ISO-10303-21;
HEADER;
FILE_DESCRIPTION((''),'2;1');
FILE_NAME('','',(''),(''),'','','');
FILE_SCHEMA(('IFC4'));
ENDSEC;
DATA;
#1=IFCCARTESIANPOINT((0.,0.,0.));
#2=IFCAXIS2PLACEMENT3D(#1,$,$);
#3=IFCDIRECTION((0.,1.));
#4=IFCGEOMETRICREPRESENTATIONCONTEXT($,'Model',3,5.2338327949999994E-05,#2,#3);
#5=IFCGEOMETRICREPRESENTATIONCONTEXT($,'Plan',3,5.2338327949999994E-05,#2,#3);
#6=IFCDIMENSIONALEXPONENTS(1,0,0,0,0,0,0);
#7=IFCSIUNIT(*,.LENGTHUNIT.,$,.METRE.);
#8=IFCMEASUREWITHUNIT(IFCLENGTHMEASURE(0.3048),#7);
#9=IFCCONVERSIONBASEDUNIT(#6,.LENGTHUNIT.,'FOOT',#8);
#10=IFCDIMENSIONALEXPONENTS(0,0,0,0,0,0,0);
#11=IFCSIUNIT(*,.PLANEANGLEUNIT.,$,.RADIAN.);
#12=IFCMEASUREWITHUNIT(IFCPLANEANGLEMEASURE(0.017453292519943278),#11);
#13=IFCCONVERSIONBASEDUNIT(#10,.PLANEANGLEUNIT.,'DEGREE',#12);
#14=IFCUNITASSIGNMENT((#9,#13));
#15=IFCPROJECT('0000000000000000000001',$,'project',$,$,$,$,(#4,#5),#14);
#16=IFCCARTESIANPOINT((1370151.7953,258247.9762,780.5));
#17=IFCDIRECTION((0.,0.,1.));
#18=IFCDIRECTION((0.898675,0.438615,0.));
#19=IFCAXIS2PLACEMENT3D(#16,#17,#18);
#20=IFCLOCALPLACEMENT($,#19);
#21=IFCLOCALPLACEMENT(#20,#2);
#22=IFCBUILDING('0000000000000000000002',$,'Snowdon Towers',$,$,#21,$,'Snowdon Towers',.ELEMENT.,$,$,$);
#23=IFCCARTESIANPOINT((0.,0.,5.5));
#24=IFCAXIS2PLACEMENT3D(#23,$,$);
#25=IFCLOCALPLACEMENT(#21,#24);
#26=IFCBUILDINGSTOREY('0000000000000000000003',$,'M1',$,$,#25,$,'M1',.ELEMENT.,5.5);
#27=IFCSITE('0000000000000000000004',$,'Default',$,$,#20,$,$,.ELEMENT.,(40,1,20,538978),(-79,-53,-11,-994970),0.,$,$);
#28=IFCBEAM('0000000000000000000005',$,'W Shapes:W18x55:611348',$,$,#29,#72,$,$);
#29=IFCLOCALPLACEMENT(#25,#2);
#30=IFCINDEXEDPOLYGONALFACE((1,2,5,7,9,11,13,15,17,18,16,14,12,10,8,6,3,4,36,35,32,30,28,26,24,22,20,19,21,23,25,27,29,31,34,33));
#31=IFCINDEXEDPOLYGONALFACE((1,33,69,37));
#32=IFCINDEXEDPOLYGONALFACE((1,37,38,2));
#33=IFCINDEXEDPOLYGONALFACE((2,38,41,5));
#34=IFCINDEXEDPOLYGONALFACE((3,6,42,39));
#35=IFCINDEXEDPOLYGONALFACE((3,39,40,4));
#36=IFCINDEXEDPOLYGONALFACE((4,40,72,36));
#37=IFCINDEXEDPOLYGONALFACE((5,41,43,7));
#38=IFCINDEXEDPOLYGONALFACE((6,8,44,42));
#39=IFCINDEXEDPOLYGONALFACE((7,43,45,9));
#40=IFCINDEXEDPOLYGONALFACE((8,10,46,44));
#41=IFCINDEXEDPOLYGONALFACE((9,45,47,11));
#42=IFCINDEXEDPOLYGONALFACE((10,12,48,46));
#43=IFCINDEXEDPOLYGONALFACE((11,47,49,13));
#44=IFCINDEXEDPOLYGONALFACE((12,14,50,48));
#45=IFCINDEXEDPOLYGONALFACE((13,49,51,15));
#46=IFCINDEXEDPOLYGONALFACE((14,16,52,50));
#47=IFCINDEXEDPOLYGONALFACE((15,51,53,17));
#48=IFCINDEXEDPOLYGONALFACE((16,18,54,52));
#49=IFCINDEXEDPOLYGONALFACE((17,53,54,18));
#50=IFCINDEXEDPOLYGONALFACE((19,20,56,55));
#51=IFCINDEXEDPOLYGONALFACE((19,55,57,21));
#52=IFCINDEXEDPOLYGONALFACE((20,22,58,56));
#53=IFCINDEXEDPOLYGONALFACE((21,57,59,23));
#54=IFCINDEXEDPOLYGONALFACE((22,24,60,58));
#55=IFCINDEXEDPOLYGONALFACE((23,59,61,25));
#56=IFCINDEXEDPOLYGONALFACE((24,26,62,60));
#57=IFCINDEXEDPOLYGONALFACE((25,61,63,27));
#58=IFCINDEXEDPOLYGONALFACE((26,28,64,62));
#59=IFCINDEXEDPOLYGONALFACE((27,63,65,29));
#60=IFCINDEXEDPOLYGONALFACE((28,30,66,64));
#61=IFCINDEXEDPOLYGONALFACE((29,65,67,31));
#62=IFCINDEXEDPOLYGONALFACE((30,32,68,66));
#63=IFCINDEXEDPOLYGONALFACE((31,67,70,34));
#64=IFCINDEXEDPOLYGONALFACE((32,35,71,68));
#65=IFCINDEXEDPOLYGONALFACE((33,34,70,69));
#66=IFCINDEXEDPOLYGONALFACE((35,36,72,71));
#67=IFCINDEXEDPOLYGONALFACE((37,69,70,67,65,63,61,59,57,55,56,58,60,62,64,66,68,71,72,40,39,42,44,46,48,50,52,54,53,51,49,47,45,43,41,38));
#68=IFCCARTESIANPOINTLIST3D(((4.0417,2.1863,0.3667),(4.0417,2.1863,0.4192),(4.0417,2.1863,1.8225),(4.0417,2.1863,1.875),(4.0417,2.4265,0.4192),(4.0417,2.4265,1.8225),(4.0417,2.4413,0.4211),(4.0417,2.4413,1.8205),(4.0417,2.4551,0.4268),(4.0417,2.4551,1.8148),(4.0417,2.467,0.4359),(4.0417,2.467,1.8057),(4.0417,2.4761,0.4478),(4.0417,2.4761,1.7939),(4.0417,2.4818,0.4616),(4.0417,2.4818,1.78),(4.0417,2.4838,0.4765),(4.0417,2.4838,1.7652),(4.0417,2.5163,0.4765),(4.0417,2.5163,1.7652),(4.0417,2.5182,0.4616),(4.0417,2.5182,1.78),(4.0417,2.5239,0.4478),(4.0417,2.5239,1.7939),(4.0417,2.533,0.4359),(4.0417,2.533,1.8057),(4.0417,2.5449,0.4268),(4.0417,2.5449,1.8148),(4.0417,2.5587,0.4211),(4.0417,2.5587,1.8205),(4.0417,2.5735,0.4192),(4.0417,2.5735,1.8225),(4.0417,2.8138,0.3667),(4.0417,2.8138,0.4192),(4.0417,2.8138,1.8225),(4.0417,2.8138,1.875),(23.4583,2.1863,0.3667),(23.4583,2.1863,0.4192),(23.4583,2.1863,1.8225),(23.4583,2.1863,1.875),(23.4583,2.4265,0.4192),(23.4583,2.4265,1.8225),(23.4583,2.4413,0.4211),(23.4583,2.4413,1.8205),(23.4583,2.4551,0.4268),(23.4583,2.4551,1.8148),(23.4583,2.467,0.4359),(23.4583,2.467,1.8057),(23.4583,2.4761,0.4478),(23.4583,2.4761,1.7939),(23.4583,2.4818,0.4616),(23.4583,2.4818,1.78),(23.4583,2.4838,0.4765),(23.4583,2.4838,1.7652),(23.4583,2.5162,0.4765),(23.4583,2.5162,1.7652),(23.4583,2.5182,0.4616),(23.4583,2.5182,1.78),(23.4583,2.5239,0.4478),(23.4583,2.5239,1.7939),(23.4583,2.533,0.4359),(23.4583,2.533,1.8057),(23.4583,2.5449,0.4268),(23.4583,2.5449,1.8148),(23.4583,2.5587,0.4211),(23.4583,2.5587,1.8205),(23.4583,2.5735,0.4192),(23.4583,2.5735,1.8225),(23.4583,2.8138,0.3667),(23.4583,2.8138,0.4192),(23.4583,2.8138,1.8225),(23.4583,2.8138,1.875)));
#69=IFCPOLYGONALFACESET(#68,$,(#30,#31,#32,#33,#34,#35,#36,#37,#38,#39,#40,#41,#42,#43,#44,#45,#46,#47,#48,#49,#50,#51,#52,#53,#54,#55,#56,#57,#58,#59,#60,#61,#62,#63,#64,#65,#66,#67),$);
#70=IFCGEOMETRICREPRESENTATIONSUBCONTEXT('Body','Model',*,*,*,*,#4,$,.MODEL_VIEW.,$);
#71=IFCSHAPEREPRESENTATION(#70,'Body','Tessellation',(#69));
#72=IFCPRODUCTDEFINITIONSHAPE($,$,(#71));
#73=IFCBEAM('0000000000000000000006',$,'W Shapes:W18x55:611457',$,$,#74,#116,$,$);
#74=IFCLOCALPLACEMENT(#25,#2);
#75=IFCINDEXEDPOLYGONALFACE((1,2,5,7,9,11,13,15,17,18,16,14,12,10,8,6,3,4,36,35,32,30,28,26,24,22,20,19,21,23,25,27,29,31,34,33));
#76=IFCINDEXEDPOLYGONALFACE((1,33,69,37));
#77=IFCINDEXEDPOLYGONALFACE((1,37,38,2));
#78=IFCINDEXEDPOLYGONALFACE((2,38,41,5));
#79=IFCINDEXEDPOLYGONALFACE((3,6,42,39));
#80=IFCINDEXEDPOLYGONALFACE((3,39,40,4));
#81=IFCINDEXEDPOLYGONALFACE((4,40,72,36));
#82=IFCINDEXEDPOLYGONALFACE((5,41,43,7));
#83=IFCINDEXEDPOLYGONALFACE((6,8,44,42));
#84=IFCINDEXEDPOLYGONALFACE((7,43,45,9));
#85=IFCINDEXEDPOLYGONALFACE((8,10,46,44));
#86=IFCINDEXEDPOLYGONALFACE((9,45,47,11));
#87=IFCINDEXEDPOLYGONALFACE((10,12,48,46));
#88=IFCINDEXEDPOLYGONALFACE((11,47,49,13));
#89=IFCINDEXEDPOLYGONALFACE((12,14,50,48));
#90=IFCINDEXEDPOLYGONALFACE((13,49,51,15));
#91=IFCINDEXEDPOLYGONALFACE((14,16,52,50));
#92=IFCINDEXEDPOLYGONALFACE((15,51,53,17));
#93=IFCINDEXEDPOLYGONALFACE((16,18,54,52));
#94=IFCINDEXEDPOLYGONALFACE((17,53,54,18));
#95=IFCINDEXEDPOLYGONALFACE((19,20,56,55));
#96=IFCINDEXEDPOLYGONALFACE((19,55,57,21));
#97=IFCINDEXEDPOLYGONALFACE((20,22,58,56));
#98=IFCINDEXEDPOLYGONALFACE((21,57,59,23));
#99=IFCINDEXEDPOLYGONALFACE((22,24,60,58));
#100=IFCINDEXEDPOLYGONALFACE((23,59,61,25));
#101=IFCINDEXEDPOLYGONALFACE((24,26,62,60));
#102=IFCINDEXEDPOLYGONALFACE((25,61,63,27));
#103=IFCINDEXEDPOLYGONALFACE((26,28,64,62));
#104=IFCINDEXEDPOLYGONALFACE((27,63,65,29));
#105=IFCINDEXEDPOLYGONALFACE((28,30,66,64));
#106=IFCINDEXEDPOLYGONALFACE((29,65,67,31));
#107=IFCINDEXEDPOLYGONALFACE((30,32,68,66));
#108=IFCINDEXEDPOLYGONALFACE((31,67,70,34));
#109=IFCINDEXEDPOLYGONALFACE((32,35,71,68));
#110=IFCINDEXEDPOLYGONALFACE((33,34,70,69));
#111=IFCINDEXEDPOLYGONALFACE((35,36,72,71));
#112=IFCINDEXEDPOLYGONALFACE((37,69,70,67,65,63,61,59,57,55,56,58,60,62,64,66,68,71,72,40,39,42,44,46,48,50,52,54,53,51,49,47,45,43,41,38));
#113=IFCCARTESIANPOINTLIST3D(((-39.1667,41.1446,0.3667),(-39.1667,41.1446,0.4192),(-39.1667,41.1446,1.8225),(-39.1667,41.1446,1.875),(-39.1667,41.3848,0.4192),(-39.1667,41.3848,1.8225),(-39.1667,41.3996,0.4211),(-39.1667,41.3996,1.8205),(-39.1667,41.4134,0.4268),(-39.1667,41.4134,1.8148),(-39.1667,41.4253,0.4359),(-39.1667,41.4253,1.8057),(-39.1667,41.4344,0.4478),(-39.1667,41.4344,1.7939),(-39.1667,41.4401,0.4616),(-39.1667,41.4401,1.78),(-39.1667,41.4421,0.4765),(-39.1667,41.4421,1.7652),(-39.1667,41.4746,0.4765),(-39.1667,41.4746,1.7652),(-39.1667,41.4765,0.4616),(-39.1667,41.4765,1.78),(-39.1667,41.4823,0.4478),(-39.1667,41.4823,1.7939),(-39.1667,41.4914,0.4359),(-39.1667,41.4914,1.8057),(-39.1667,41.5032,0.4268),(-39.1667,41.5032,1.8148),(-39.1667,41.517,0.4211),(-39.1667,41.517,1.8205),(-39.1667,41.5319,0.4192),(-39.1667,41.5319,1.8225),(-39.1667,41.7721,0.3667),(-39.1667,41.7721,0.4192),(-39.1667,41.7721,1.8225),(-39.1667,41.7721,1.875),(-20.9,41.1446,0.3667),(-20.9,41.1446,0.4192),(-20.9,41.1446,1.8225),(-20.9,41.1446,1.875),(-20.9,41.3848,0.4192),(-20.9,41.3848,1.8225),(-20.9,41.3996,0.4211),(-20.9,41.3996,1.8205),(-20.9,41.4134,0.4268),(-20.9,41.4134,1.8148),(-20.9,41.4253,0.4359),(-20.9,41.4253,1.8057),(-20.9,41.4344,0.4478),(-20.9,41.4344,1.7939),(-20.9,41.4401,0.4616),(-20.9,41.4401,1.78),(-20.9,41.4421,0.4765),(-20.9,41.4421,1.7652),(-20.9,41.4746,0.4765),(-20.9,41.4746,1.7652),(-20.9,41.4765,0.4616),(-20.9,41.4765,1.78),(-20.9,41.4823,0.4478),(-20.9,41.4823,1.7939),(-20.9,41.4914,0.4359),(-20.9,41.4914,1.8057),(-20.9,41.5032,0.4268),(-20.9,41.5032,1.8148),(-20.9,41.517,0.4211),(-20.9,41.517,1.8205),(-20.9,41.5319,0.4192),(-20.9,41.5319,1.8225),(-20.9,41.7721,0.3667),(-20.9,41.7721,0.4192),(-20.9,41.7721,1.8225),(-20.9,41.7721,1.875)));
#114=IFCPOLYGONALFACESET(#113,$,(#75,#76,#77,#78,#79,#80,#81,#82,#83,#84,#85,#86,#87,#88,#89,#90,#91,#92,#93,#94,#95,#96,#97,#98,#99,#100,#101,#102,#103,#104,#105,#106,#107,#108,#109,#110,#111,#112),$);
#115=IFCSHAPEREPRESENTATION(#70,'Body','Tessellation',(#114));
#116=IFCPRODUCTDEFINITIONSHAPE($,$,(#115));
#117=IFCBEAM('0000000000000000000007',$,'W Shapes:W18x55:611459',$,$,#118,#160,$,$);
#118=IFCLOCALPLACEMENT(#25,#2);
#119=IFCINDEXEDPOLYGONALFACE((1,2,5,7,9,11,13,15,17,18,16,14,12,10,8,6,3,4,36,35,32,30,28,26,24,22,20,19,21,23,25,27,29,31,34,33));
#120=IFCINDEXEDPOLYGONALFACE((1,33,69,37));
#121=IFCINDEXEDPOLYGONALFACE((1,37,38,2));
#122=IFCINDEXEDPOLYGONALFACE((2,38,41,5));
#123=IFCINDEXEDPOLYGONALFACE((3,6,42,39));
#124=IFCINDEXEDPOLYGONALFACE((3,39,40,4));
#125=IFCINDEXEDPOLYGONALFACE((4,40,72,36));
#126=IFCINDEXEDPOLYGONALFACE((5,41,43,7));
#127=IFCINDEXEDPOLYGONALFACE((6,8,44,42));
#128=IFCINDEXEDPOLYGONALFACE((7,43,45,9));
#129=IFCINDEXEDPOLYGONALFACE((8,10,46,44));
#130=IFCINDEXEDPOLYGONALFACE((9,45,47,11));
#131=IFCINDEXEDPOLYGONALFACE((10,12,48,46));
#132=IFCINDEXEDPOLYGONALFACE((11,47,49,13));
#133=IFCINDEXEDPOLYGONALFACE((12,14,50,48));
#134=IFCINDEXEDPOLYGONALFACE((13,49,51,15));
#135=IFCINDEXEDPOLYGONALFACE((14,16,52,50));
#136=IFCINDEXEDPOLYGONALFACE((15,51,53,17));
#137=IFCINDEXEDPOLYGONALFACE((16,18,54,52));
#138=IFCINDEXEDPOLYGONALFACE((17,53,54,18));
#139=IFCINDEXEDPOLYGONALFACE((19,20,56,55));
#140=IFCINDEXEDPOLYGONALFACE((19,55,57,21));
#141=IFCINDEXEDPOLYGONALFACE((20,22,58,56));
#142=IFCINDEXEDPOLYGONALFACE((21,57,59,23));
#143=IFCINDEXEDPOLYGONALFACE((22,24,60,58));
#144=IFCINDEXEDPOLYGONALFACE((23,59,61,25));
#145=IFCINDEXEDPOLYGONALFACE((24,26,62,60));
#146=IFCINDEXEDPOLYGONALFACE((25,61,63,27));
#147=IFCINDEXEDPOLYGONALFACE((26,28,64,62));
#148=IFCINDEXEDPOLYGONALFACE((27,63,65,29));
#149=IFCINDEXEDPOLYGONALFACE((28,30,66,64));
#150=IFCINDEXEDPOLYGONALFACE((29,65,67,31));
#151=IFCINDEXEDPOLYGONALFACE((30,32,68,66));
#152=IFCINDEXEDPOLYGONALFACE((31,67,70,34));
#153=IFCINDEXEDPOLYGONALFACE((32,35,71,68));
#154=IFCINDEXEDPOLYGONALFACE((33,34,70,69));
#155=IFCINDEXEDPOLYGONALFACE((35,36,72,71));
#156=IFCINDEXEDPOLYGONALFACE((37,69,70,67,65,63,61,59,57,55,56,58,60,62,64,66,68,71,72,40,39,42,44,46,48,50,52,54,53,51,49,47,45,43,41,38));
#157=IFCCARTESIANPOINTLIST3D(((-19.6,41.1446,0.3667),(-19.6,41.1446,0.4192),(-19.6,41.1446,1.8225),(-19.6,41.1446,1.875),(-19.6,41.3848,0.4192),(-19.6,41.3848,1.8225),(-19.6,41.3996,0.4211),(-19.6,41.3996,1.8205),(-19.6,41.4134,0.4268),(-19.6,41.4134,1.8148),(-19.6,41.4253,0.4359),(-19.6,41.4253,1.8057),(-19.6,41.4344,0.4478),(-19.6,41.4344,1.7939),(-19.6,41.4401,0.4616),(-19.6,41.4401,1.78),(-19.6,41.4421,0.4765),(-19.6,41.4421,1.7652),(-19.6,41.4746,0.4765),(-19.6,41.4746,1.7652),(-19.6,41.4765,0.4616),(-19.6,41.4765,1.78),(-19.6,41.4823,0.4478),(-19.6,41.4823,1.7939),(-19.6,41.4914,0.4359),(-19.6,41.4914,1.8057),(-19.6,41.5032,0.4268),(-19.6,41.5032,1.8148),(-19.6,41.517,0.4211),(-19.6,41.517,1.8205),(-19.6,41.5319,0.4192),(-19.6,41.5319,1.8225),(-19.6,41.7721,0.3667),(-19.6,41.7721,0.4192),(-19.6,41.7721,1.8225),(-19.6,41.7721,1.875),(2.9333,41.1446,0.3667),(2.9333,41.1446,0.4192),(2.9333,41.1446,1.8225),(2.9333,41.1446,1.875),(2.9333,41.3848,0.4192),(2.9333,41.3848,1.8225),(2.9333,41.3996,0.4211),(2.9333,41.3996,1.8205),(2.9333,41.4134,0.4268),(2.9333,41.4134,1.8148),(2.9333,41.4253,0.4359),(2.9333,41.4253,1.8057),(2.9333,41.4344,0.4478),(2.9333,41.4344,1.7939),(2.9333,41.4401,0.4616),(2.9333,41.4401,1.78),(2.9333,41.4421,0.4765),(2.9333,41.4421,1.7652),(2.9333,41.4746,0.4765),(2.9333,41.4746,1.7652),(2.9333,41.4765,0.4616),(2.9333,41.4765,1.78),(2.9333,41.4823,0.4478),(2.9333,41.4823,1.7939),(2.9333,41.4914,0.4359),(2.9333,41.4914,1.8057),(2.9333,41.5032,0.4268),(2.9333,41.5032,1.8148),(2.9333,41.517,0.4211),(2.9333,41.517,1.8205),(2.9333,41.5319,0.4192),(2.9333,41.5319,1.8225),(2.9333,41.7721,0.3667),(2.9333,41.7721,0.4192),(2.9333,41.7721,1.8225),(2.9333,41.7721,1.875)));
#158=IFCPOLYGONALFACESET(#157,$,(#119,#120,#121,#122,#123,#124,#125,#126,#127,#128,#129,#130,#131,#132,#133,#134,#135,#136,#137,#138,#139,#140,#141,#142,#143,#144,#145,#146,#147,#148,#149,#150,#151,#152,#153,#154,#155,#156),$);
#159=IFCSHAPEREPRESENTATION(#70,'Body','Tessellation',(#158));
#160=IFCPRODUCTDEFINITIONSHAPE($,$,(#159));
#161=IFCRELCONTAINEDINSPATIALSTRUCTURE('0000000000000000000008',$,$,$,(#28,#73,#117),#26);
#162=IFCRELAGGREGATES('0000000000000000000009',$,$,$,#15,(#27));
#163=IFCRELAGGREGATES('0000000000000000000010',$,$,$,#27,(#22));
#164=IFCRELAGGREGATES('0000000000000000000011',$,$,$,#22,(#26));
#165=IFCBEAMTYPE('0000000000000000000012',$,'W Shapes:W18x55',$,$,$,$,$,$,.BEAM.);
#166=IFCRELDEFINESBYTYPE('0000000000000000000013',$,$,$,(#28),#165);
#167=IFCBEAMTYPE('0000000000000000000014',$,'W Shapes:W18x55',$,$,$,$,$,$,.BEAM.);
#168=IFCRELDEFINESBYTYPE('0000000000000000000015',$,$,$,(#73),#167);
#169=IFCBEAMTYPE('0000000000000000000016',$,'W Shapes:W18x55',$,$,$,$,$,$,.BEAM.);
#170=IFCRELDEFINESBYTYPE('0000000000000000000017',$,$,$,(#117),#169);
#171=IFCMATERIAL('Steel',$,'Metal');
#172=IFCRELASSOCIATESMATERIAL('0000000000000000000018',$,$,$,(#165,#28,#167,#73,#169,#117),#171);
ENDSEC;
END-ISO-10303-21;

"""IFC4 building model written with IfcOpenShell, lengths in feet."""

from ifc_helpers import new_model, entity, si_unit, converted_unit, direction, frame, origin, place, context, subcontext, project, spatial, line, arc, indexed_curve, outline, extrude, source, transform, mapped, material, type_object, type_shapes, element, save


model = new_model("IFC4")

# Units and contexts
model_context = context("Model", 3, precision=5.2338327949999994e-05, world=origin(), true_north=direction((0.0, 1.0)))
plan_context = context("Plan", 3, precision=5.2338327949999994e-05, world=origin(), true_north=direction((0.0, 1.0)))
body_context = subcontext(model_context, "Body", "Model", "MODEL_VIEW")
ifc_project = project(units=[converted_unit("LENGTHUNIT", "FOOT", entity("IfcLengthMeasure", 0.3048), si_unit("LENGTHUNIT", "METRE"), dimensions=[1, 0, 0, 0, 0, 0, 0]), converted_unit("PLANEANGLEUNIT", "DEGREE", entity("IfcPlaneAngleMeasure", 0.017453292519943278), si_unit("PLANEANGLEUNIT", "RADIAN"), dimensions=[0, 0, 0, 0, 0, 0, 0])], contexts=[model_context, plan_context])

# Site, building, storey
site_placement = place(None, frame((1370151.7953, 258247.9762, 780.5), z_axis=(0.0, 0.0, 1.0), x_axis=(0.898675, 0.438615, 0.0)))
site = spatial("IfcSite", under=ifc_project, at=site_placement, Name="Default", CompositionType="ELEMENT", RefLatitude=(40, 1, 20, 538978), RefLongitude=(-79, -53, -11, -994970), RefElevation=0.0)
building_placement = place(site_placement, origin())
building = spatial("IfcBuilding", under=site, at=building_placement, Name="Snowdon Towers", LongName="Snowdon Towers", CompositionType="ELEMENT")
storey_placement = place(building_placement, frame((0.0, 0.0, 5.5)))
storey = spatial("IfcBuildingStorey", under=building, at=storey_placement, Name="M1", LongName="M1", CompositionType="ELEMENT", Elevation=5.5)

# Beams
ifc_material_1 = material(Name="Steel", Category="Metal")
beam_type_1 = type_object("IfcBeamType", Name="W Shapes:W18x55", PredefinedType="BEAM", material=ifc_material_1)
shared_shape_1 = source(origin(), body_context, "Body", "SweptSolid", [
    extrude(outline(indexed_curve([(-0.7542, -0.3138), (-0.7017, -0.3138), (-0.7017, -0.0735), (-0.6849, -0.033), (-0.6444, -0.0162), (0.6444, -0.0162), (0.6849, -0.033), (0.7017, -0.0735), (0.7017, -0.3138), (0.7542, -0.3138), (0.7542, 0.3138), (0.7017, 0.3138), (0.7017, 0.0735), (0.6849, 0.033), (0.6444, 0.0163), (-0.6444, 0.0163), (-0.6849, 0.033), (-0.7017, 0.0735), (-0.7017, 0.3137), (-0.7542, 0.3137)], segments=[line(1, 2, 3), arc(3, 4, 5), line(5, 6), arc(6, 7, 8), line(8, 9, 10, 11, 12, 13), arc(13, 14, 15), line(15, 16), arc(16, 17, 18), line(18, 19, 20, 1)], self_intersect=False)), frame((-9.7917, 0.0, 0.0), z_axis=(1.0, 0.0, 0.0), x_axis=(0.0, 0.0, -1.0)), (0.0, 0.0, 1.0), 19.4167),
])
type_shapes(beam_type_1, [shared_shape_1])
beam_1_placement = place(storey_placement, frame((13.8333, 2.5, 1.1208)))
element("IfcBeam", 1, at=beam_1_placement, inside=storey, type_object=beam_type_1, material=ifc_material_1, Name="W Shapes:W18x55:611348", context=body_context, shape_type="MappedRepresentation", body=[
    mapped(shared_shape_1, transform((0.0, 0.0, 0.0), scale=1.0)),
])
beam_type_2 = type_object("IfcBeamType", Name="W Shapes:W18x55", PredefinedType="BEAM", material=ifc_material_1)
shared_shape_2 = source(origin(), body_context, "Body", "SweptSolid", [
    extrude(outline(indexed_curve([(-0.7542, -0.3138), (-0.7017, -0.3138), (-0.7017, -0.0735), (-0.6849, -0.033), (-0.6444, -0.0162), (0.6444, -0.0162), (0.6849, -0.033), (0.7017, -0.0735), (0.7017, -0.3138), (0.7542, -0.3138), (0.7542, 0.3138), (0.7017, 0.3138), (0.7017, 0.0735), (0.6849, 0.033), (0.6444, 0.0163), (-0.6444, 0.0163), (-0.6849, 0.033), (-0.7017, 0.0735), (-0.7017, 0.3137), (-0.7542, 0.3137)], segments=[line(1, 2, 3), arc(3, 4, 5), line(5, 6), arc(6, 7, 8), line(8, 9, 10, 11, 12, 13), arc(13, 14, 15), line(15, 16), arc(16, 17, 18), line(18, 19, 20, 1)], self_intersect=False)), frame((-9.1875, 0.0, 0.0), z_axis=(1.0, 0.0, 0.0), x_axis=(0.0, 0.0, -1.0)), (0.0, 0.0, 1.0), 18.2667),
])
type_shapes(beam_type_2, [shared_shape_2])
beam_2_placement = place(storey_placement, frame((-29.9792, 41.4583, 1.1208)))
element("IfcBeam", 2, at=beam_2_placement, inside=storey, type_object=beam_type_2, material=ifc_material_1, Name="W Shapes:W18x55:611457", context=body_context, shape_type="MappedRepresentation", body=[
    mapped(shared_shape_2, transform((0.0, 0.0, 0.0), scale=1.0)),
])
beam_type_3 = type_object("IfcBeamType", Name="W Shapes:W18x55", PredefinedType="BEAM", material=ifc_material_1)
shared_shape_3 = source(origin(), body_context, "Body", "SweptSolid", [
    extrude(outline(indexed_curve([(-0.7542, -0.3138), (-0.7017, -0.3138), (-0.7017, -0.0735), (-0.6849, -0.033), (-0.6444, -0.0162), (0.6444, -0.0162), (0.6849, -0.033), (0.7017, -0.0735), (0.7017, -0.3138), (0.7542, -0.3138), (0.7542, 0.3138), (0.7017, 0.3138), (0.7017, 0.0735), (0.6849, 0.033), (0.6444, 0.0163), (-0.6444, 0.0163), (-0.6849, 0.033), (-0.7017, 0.0735), (-0.7017, 0.3137), (-0.7542, 0.3137)], segments=[line(1, 2, 3), arc(3, 4, 5), line(5, 6), arc(6, 7, 8), line(8, 9, 10, 11, 12, 13), arc(13, 14, 15), line(15, 16), arc(16, 17, 18), line(18, 19, 20, 1)], self_intersect=False)), frame((-11.35, 0.0, 0.0), z_axis=(1.0, 0.0, 0.0), x_axis=(0.0, 0.0, -1.0)), (0.0, 0.0, 1.0), 22.5333),
])
type_shapes(beam_type_3, [shared_shape_3])
beam_3_placement = place(storey_placement, frame((-8.25, 41.4583, 1.1208)))
element("IfcBeam", 3, at=beam_3_placement, inside=storey, type_object=beam_type_3, material=ifc_material_1, Name="W Shapes:W18x55:611459", context=body_context, shape_type="MappedRepresentation", body=[
    mapped(shared_shape_3, transform((0.0, 0.0, 0.0), scale=1.0)),
])

save(model, "model.ifc")
